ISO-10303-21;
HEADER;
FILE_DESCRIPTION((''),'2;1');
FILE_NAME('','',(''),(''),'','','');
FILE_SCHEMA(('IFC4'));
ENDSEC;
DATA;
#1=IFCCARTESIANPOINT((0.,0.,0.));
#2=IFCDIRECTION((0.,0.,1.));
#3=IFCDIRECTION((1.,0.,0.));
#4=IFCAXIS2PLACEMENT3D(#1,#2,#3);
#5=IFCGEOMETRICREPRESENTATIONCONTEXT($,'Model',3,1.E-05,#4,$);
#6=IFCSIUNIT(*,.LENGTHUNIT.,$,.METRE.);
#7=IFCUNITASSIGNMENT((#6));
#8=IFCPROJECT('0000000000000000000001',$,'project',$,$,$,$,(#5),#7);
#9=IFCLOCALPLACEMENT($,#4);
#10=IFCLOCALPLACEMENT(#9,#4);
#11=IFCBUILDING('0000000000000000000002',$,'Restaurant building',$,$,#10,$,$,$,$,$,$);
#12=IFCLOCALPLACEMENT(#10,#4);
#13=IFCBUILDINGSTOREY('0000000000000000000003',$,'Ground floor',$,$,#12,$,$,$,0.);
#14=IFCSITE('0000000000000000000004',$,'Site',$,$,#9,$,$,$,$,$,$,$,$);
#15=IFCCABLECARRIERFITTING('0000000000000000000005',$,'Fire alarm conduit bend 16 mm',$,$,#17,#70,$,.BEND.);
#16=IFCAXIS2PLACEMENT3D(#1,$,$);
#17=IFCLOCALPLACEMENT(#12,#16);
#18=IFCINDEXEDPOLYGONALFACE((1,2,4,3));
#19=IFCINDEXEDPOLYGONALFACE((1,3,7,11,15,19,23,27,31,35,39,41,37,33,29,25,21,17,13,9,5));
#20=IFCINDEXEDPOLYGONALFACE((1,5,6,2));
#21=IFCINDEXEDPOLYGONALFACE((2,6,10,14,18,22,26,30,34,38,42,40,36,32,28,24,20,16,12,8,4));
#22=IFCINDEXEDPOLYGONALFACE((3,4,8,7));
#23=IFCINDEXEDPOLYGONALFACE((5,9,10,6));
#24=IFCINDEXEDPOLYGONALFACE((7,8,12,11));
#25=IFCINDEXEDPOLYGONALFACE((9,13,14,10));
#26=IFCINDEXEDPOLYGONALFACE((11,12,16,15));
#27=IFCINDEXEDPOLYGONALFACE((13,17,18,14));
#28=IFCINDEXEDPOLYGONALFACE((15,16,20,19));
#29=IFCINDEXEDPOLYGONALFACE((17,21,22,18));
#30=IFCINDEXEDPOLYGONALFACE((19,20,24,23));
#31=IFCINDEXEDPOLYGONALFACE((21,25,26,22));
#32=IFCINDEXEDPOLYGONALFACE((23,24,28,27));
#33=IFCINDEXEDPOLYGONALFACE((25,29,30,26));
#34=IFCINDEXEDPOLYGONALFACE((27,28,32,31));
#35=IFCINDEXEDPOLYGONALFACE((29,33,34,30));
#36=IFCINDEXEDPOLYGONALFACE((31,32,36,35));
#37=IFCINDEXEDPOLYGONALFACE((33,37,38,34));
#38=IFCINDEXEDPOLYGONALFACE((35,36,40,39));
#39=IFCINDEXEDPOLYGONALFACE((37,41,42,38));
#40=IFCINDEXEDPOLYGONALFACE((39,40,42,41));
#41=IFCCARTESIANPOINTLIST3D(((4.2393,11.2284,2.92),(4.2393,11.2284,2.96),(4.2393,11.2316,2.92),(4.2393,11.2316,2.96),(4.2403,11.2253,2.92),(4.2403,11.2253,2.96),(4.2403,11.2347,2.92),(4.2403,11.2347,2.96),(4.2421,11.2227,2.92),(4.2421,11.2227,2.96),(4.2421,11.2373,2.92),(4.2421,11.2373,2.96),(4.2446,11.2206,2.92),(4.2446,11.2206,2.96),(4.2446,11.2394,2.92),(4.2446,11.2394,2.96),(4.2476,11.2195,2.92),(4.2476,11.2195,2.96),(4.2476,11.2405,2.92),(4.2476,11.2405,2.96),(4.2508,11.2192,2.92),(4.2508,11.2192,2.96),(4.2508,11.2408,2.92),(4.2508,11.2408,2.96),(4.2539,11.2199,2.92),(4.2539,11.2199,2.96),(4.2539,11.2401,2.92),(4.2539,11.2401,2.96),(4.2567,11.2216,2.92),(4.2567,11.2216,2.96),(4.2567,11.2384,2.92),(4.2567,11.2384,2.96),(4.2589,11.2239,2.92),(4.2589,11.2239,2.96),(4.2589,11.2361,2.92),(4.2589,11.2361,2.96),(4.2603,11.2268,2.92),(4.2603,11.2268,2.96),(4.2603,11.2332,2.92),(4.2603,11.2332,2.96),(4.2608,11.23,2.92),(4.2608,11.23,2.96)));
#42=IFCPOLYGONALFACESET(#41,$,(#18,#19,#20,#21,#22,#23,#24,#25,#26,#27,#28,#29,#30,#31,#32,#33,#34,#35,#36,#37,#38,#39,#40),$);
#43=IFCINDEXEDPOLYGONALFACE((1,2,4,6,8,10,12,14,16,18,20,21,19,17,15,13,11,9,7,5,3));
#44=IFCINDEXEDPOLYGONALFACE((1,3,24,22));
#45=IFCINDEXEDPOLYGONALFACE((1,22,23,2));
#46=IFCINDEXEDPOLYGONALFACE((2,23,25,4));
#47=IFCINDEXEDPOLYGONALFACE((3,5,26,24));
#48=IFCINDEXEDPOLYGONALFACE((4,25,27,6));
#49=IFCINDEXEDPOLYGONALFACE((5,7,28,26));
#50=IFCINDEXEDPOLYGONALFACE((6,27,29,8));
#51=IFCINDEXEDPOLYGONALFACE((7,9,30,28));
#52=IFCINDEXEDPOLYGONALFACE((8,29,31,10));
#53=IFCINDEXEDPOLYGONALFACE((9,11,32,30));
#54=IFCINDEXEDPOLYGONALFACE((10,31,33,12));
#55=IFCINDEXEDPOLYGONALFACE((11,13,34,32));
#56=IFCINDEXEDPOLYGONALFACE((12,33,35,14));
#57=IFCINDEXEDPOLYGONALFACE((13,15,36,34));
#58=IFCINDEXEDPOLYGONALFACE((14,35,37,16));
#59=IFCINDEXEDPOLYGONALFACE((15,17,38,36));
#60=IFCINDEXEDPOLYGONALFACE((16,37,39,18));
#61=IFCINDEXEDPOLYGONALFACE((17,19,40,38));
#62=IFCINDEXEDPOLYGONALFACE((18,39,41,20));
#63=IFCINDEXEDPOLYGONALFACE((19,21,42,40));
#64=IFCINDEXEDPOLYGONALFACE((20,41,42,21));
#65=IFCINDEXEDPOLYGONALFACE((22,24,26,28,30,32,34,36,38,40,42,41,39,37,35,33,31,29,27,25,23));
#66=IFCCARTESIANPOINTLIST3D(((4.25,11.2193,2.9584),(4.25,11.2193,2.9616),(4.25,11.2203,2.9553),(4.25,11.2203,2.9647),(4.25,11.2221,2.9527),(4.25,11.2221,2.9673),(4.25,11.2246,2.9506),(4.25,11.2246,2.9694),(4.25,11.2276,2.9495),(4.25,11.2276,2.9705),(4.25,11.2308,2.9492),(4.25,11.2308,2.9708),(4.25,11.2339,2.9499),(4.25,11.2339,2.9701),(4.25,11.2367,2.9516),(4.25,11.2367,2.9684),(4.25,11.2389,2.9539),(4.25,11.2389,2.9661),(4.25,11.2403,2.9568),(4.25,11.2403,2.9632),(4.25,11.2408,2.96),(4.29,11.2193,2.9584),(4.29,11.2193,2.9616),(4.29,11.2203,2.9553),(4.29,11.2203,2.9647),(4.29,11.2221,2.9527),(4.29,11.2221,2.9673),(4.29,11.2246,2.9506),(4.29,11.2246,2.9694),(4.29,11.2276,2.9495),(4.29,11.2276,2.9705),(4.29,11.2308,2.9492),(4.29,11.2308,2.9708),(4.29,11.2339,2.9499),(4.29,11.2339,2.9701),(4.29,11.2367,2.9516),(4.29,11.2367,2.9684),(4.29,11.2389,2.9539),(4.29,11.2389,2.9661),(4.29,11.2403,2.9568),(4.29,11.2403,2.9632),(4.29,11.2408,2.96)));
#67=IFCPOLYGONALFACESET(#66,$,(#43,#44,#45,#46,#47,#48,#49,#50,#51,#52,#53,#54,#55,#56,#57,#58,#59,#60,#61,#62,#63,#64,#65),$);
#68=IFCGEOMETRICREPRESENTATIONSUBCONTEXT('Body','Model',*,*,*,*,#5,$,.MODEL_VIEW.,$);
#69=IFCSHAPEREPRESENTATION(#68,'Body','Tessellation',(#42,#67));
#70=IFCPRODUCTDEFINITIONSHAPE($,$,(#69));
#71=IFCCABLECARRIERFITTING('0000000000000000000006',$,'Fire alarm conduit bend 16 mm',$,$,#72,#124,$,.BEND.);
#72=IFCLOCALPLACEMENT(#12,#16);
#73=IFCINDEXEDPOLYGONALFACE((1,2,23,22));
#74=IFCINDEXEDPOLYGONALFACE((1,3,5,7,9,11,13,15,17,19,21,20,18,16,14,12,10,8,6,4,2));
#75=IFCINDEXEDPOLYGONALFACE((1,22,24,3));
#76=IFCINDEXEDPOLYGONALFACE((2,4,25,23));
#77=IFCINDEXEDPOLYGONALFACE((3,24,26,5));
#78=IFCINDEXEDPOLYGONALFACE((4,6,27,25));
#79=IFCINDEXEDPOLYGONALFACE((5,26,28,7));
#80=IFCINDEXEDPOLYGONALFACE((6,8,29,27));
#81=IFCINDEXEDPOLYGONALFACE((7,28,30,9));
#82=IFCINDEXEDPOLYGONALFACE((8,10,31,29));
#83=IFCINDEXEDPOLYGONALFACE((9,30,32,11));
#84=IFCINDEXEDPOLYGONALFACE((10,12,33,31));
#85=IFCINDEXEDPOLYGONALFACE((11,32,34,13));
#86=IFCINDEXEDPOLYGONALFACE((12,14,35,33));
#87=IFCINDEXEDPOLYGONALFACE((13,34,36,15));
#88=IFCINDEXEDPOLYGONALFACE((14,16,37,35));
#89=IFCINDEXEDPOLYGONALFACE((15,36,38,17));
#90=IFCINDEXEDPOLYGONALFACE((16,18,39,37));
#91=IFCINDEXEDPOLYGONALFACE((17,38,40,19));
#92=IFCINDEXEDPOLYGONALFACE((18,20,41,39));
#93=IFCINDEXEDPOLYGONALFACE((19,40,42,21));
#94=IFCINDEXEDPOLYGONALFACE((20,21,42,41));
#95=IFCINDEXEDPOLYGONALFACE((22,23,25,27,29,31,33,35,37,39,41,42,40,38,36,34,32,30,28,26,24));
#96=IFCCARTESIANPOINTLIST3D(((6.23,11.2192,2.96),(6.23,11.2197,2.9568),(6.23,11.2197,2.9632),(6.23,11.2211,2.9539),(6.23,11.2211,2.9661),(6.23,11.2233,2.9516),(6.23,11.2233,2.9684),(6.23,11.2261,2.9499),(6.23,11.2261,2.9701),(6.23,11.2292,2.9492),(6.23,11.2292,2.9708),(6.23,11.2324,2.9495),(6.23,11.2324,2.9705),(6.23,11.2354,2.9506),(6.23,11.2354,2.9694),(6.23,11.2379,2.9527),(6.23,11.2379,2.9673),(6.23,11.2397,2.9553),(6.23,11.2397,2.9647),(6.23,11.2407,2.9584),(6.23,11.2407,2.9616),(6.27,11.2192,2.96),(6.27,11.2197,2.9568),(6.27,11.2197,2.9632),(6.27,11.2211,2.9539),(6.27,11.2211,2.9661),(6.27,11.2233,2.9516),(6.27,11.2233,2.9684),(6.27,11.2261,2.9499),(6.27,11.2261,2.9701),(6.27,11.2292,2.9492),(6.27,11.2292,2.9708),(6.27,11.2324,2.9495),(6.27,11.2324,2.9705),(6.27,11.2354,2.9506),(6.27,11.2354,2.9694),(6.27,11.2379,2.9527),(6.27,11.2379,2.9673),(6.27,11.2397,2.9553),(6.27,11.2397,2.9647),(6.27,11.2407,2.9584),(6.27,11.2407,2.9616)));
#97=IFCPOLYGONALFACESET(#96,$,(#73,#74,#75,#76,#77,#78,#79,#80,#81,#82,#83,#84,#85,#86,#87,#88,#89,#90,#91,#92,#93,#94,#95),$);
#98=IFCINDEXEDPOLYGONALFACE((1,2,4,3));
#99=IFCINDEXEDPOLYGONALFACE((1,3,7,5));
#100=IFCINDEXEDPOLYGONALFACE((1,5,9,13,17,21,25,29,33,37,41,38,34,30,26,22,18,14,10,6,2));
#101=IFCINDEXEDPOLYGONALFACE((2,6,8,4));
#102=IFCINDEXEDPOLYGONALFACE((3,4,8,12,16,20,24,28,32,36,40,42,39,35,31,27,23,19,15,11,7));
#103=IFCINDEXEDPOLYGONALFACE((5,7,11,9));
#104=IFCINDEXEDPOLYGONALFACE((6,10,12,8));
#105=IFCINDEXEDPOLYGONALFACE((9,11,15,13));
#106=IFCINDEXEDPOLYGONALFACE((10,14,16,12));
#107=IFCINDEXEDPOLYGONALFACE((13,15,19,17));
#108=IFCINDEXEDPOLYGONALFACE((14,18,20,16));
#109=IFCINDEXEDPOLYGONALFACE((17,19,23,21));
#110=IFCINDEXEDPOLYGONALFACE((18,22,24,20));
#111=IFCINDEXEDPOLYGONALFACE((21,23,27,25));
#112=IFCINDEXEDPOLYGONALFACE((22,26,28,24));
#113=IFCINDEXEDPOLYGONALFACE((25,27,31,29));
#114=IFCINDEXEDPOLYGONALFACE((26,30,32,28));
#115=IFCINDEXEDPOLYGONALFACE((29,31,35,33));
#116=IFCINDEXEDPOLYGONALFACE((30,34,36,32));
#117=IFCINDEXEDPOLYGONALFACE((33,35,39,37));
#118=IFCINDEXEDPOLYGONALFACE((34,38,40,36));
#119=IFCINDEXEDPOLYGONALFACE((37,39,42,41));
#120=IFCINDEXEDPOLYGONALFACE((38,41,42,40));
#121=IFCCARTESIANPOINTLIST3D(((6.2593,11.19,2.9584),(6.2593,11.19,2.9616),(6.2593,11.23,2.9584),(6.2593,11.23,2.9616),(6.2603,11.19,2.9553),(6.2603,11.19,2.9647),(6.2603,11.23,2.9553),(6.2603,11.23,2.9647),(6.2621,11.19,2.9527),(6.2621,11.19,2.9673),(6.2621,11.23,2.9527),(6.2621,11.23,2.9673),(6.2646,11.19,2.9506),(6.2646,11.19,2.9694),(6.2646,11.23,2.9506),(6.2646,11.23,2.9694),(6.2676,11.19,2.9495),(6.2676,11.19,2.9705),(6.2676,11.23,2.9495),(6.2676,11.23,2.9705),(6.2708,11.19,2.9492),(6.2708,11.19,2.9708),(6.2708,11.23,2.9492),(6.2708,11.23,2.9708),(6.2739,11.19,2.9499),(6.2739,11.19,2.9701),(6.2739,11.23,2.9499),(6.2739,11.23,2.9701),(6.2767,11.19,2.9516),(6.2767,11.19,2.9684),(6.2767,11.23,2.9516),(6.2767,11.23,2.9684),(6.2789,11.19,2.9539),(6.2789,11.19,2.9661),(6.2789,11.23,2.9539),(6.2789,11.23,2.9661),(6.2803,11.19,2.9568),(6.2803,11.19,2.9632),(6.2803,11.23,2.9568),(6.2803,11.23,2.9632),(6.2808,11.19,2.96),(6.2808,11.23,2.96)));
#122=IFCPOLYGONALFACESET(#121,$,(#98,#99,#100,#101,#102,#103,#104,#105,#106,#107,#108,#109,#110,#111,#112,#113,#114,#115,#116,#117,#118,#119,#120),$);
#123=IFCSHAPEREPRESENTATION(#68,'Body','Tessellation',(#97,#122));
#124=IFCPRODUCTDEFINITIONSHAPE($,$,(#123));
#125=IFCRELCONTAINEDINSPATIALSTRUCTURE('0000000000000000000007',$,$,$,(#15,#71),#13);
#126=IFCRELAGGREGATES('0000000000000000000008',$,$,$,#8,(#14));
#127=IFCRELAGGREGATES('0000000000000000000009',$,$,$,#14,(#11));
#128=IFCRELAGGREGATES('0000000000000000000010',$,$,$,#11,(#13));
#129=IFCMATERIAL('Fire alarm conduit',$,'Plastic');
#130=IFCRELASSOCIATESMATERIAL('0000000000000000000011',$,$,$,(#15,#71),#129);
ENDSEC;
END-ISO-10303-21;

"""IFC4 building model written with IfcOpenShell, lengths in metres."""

from ifc_helpers import new_model, si_unit, frame, origin_with_axes, origin_2d, place, context, subcontext, project, spatial, circle, extrude, material, element, save


model = new_model("IFC4")

# Units and contexts
model_context = context("Model", 3, precision=1e-05, world=origin_with_axes())
body_context = subcontext(model_context, "Body", "Model", "MODEL_VIEW")
ifc_project = project(units=[si_unit("LENGTHUNIT", "METRE")], contexts=[model_context])

# Site, building, storey
site_placement = place(None, origin_with_axes())
site = spatial("IfcSite", under=ifc_project, at=site_placement, Name="Site")
building_placement = place(site_placement, origin_with_axes())
building = spatial("IfcBuilding", under=site, at=building_placement, Name="Restaurant building")
storey_placement = place(building_placement, origin_with_axes())
storey = spatial("IfcBuildingStorey", under=building, at=storey_placement, Name="Ground floor", Elevation=0.0)

# Shared definitions
ifc_material_1 = material(Name="Fire alarm conduit", Category="Plastic")

# Cable carrier fittings
cable_carrier_fitting_1_placement = place(storey_placement, frame((4.25, 11.23, 2.96)))
element("IfcCableCarrierFitting", 1, at=cable_carrier_fitting_1_placement, inside=storey, material=ifc_material_1, Name="Fire alarm conduit bend 16 mm", PredefinedType="BEND", context=body_context, shape_type="SweptSolid", body=[
    extrude(circle(Radius=0.0108, at=origin_2d()), frame((0.0, 0.0, 0.0), z_axis=(0.0, 0.0, -1.0), x_axis=(1.0, 0.0, 0.0)), (0.0, 0.0, 1.0), 0.04),
    extrude(circle(Radius=0.0108, at=origin_2d()), frame((0.0, 0.0, 0.0), z_axis=(1.0, 0.0, 0.0), x_axis=(0.0, 1.0, 0.0)), (0.0, 0.0, 1.0), 0.04),
])
cable_carrier_fitting_2_placement = place(storey_placement, frame((6.27, 11.23, 2.96)))
element("IfcCableCarrierFitting", 2, at=cable_carrier_fitting_2_placement, inside=storey, material=ifc_material_1, Name="Fire alarm conduit bend 16 mm", PredefinedType="BEND", context=body_context, shape_type="SweptSolid", body=[
    extrude(circle(Radius=0.0108, at=origin_2d()), frame((0.0, 0.0, 0.0), z_axis=(-1.0, 0.0, 0.0), x_axis=(0.0, -1.0, 0.0)), (0.0, 0.0, 1.0), 0.04),
    extrude(circle(Radius=0.0108, at=origin_2d()), frame((0.0, 0.0, 0.0), z_axis=(0.0, -1.0, 0.0), x_axis=(1.0, 0.0, 0.0)), (0.0, 0.0, 1.0), 0.04),
])

save(model, "model.ifc")
